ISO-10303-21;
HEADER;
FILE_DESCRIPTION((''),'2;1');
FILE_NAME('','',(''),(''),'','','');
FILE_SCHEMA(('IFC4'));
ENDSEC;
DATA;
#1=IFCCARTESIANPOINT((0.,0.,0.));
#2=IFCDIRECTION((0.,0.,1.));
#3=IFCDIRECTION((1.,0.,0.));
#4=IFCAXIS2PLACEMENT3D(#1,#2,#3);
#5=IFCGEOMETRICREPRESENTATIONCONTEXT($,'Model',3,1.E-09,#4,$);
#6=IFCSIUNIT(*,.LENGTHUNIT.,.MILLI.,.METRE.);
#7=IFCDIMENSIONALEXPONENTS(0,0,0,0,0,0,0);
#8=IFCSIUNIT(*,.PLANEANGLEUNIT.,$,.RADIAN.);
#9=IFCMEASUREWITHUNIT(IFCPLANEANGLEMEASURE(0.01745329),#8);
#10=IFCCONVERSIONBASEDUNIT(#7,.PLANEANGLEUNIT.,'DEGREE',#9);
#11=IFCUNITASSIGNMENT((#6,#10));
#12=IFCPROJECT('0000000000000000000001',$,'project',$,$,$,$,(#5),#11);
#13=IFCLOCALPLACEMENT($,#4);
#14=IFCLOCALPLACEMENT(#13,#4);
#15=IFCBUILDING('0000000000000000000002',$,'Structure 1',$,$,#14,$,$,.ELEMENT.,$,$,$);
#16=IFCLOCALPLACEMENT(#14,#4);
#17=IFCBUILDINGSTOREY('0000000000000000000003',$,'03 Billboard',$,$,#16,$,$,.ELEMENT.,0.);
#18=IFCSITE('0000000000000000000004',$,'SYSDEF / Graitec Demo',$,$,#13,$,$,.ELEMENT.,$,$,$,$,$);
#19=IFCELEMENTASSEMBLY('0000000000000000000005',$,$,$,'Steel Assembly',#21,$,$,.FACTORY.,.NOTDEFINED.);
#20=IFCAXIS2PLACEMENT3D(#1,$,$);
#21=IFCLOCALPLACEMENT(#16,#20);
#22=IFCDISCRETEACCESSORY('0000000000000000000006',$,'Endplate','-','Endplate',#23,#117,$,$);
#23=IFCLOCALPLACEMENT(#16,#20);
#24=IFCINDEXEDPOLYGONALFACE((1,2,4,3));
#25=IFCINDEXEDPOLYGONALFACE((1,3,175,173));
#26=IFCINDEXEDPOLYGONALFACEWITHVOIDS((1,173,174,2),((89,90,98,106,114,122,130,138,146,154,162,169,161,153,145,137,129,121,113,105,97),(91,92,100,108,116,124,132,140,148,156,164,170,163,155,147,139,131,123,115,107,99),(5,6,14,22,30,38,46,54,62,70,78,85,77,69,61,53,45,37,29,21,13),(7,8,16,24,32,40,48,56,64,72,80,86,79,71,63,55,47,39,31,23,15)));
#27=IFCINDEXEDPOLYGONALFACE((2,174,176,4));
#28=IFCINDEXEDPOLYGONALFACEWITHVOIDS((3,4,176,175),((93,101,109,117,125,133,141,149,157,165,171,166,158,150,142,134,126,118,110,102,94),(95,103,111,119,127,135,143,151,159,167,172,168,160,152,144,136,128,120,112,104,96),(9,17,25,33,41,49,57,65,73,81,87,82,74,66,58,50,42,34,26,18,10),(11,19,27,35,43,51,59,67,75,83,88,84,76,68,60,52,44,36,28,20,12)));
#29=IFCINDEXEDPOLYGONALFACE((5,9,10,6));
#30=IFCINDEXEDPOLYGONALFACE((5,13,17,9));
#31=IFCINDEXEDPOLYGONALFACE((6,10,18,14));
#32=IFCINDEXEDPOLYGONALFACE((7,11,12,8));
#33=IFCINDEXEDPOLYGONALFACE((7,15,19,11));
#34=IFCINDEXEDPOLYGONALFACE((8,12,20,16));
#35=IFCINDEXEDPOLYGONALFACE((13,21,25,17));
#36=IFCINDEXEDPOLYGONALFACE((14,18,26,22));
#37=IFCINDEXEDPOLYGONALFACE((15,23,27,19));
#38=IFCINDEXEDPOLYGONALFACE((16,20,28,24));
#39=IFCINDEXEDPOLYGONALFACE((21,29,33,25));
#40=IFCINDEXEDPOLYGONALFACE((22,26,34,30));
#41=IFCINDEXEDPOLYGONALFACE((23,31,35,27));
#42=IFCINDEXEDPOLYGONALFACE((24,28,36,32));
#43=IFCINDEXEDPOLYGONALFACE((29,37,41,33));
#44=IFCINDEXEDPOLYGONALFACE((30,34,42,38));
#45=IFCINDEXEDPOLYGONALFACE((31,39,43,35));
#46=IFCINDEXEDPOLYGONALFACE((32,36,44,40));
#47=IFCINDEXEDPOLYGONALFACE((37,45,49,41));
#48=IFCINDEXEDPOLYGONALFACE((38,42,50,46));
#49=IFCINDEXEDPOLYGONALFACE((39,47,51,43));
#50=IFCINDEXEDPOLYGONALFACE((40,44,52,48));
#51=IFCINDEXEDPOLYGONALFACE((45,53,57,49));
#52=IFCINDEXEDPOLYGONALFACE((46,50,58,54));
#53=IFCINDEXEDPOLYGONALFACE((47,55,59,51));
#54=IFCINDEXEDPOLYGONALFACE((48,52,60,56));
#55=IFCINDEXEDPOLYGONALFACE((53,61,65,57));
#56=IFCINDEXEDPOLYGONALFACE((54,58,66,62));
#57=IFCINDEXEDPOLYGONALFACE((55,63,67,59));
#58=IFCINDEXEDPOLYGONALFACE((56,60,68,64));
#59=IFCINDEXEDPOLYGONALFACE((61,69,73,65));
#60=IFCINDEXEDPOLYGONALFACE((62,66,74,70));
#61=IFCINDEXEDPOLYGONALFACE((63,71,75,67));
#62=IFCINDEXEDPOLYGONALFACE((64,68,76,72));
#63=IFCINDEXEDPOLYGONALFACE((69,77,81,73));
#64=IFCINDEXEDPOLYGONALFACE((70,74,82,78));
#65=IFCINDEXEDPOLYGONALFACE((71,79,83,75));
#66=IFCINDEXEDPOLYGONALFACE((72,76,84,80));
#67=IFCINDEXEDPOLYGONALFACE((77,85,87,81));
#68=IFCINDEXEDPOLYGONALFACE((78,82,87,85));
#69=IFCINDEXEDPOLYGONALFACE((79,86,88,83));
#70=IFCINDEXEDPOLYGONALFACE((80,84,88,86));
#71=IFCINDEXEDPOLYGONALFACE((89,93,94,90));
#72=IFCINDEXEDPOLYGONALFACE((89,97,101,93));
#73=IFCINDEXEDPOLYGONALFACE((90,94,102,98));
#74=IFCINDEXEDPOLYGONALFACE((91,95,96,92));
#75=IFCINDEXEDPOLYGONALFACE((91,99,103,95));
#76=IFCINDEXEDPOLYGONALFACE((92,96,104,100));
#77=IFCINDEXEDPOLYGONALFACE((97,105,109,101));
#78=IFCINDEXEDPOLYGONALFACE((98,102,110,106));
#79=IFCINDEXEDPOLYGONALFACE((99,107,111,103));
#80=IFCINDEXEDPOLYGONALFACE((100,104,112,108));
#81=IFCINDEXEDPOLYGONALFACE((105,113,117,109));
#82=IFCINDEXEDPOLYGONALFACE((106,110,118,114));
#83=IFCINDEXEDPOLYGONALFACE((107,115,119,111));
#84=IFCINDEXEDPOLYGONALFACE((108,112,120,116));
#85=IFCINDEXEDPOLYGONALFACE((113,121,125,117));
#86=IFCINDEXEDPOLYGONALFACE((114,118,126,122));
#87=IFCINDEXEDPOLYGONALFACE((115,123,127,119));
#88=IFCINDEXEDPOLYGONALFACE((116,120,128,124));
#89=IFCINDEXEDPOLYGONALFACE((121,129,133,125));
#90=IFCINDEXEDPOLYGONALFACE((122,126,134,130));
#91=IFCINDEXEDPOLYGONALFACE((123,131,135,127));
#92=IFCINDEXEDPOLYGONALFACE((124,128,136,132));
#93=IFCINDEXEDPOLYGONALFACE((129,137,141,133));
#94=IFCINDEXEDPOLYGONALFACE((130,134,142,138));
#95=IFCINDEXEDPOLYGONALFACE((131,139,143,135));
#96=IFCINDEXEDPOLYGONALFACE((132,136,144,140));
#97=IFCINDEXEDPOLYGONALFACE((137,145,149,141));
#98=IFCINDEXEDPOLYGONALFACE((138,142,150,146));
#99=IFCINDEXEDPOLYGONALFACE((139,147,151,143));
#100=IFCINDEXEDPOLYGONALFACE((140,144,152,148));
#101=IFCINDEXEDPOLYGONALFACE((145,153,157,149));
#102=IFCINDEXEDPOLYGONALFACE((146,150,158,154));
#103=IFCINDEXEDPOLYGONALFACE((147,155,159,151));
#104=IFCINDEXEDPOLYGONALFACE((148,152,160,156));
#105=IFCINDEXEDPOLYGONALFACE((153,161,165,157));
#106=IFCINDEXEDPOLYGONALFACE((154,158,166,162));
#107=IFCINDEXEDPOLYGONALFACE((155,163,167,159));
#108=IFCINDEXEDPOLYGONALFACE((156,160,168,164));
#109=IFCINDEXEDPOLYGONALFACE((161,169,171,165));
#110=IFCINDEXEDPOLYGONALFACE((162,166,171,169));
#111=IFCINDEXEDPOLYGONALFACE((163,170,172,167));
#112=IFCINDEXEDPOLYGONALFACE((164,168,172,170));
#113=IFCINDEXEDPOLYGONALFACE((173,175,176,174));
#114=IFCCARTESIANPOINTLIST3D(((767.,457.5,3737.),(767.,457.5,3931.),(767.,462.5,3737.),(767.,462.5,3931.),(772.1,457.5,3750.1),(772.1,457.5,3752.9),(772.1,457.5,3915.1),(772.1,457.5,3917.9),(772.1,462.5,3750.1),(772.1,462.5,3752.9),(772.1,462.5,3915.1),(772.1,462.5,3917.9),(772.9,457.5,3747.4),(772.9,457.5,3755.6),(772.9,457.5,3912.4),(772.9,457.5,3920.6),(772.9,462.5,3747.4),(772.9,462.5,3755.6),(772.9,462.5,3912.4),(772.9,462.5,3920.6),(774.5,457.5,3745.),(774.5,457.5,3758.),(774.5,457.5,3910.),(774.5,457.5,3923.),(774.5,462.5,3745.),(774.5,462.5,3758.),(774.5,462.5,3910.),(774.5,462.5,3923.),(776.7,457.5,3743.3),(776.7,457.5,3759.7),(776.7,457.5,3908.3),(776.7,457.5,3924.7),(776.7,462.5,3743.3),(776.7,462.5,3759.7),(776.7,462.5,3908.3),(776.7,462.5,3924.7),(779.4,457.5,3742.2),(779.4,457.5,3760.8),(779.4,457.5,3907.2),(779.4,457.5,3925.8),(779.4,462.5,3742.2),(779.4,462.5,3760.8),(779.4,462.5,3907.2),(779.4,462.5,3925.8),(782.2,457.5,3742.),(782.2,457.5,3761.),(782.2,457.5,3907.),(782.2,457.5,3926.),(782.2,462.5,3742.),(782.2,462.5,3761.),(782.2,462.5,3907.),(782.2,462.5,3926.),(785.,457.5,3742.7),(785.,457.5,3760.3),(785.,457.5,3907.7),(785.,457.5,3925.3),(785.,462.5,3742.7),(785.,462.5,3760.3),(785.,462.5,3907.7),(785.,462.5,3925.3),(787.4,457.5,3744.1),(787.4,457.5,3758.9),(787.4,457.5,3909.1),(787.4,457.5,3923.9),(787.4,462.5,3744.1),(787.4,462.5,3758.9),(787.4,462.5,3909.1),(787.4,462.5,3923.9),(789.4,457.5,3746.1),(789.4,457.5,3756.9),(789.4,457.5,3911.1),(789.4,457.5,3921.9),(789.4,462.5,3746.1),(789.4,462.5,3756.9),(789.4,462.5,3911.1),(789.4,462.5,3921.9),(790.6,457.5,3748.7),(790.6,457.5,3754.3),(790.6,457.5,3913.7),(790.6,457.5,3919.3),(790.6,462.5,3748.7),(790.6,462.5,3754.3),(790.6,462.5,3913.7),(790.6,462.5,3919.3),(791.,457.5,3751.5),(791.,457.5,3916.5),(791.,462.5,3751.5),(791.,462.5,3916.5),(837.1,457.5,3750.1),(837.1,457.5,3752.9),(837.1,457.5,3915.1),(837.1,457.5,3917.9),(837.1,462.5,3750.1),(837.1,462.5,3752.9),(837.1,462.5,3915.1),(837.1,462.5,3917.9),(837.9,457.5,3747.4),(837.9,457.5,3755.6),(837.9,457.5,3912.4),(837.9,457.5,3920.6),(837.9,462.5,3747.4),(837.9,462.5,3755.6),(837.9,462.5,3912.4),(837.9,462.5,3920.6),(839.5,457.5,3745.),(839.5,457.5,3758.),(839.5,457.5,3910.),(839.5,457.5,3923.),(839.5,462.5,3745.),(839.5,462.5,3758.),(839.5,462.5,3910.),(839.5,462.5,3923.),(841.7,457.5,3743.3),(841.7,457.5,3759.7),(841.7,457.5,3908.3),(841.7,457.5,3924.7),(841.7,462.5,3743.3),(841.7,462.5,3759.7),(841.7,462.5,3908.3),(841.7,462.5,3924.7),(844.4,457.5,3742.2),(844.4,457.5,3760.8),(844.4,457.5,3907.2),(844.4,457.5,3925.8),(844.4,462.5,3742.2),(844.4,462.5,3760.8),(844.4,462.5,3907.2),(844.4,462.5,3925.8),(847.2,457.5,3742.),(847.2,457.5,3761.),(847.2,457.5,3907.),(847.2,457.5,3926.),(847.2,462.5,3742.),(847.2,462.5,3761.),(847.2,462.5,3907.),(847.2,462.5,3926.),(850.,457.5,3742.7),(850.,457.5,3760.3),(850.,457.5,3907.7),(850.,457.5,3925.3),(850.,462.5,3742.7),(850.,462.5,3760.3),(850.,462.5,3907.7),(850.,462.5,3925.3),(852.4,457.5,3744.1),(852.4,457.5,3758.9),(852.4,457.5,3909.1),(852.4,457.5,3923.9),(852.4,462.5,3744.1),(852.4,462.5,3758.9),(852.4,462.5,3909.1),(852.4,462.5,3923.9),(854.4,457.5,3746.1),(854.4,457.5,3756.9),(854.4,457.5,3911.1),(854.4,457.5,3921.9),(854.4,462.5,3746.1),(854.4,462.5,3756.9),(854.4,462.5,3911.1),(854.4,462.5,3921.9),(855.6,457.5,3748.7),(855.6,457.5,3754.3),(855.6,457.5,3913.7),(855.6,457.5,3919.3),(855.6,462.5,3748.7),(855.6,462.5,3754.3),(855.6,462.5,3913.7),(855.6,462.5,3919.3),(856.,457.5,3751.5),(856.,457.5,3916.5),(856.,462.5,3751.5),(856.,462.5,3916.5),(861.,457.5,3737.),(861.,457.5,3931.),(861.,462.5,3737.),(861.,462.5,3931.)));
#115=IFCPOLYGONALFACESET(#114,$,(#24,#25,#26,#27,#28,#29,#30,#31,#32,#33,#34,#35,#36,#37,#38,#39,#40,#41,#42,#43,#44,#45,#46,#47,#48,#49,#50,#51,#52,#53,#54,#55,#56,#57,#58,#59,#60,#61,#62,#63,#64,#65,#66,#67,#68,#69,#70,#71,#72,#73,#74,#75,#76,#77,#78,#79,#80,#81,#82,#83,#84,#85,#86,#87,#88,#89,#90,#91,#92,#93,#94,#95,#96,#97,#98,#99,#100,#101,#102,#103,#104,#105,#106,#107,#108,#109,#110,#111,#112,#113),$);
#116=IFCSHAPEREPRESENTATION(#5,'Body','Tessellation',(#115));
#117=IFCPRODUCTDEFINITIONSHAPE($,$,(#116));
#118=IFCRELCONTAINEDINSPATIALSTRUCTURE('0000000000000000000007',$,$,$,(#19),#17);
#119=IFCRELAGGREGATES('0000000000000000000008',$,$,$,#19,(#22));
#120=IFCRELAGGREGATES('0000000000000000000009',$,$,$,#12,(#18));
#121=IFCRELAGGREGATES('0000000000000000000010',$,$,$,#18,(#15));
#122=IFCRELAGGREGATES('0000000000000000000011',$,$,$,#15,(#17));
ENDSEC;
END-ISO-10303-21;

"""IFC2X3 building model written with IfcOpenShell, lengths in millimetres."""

from ifc_helpers import new_model, entity, si_unit, converted_unit, frame, frame_2d, origin, origin_with_axes, place, context, project, spatial, polyline, circle, outline, extrude, element, aggregate, save


model = new_model("IFC2X3")

# Units and contexts
model_context = context("Model", 3, precision=1e-09, world=origin_with_axes())
ifc_project = project(units=[si_unit("LENGTHUNIT", "METRE", prefix="MILLI"), converted_unit("PLANEANGLEUNIT", "DEGREE", entity("IfcPlaneAngleMeasure", 0.01745329), si_unit("PLANEANGLEUNIT", "RADIAN"), dimensions=[0, 0, 0, 0, 0, 0, 0])], contexts=[model_context])

# Site, building, storey
site_placement = place(None, origin_with_axes())
site = spatial("IfcSite", under=ifc_project, at=site_placement, Name="SYSDEF / Graitec Demo", CompositionType="ELEMENT")
building_placement = place(site_placement, origin_with_axes())
building = spatial("IfcBuilding", under=site, at=building_placement, Name="Structure 1", CompositionType="ELEMENT")
storey_placement = place(building_placement, origin_with_axes())
storey = spatial("IfcBuildingStorey", under=building, at=storey_placement, Name="03 Billboard", CompositionType="ELEMENT", Elevation=0.0)

# Element assembly, discrete accessory, openings
assembly_1_placement = place(None, frame((-4406.3, 0.0, 3558.0), z_axis=(-1.0, 0.0, 0.0), x_axis=(0.0, -1.0, 0.0)))
assembly_1 = element("IfcElementAssembly", 1, at=assembly_1_placement, inside=storey, ObjectType="Steel Assembly", AssemblyPlace="FACTORY", PredefinedType="NOTDEFINED")
discrete_accessory_1_placement = place(assembly_1_placement, frame((-457.5, 373.0, -5173.3), z_axis=(-1.0, 0.0, 0.0), x_axis=(0.0, 0.0, -1.0)))
discrete_accessory_1 = element("IfcDiscreteAccessory", 2, at=discrete_accessory_1_placement, Name="Endplate", Description="-", ObjectType="Endplate", context=model_context, shape_type="SweptSolid", body=[
    extrude(outline(polyline([(0.0, 0.0), (94.0, 0.0), (94.0, 194.0), (0.0, 194.0), (0.0, 0.0)])), origin_with_axes(), (0.0, 0.0, 1.0), 5.0),
])
opening_1_placement = place(discrete_accessory_1_placement, frame((47.0, 97.0, 5.5), z_axis=(0.0, 0.0, -1.0), x_axis=(1.0, 0.0, 0.0)))
element("IfcOpeningElement", 3, at=opening_1_placement, cuts=discrete_accessory_1, ObjectType="Opening", context=model_context, shape_type="SweptSolid", body=[
    extrude(circle(Radius=9.5, at=frame_2d((32.5, 82.5), x_axis=(1.0, 0.0))), origin(), (0.0, 0.0, 1.0), 6.0),
])
opening_2_placement = place(discrete_accessory_1_placement, frame((47.0, 97.0, 5.5), z_axis=(0.0, 0.0, -1.0), x_axis=(1.0, 0.0, 0.0)))
element("IfcOpeningElement", 4, at=opening_2_placement, cuts=discrete_accessory_1, ObjectType="Opening", context=model_context, shape_type="SweptSolid", body=[
    extrude(circle(Radius=9.5, at=frame_2d((-32.5, 82.5), x_axis=(1.0, 0.0))), origin(), (0.0, 0.0, 1.0), 6.0),
])
opening_3_placement = place(discrete_accessory_1_placement, frame((47.0, 97.0, 5.5), z_axis=(0.0, 0.0, -1.0), x_axis=(1.0, 0.0, 0.0)))
element("IfcOpeningElement", 5, at=opening_3_placement, cuts=discrete_accessory_1, ObjectType="Opening", context=model_context, shape_type="SweptSolid", body=[
    extrude(circle(Radius=9.5, at=frame_2d((32.5, -82.5), x_axis=(1.0, 0.0))), origin(), (0.0, 0.0, 1.0), 6.0),
])
opening_4_placement = place(discrete_accessory_1_placement, frame((47.0, 97.0, 5.5), z_axis=(0.0, 0.0, -1.0), x_axis=(1.0, 0.0, 0.0)))
element("IfcOpeningElement", 6, at=opening_4_placement, cuts=discrete_accessory_1, ObjectType="Opening", context=model_context, shape_type="SweptSolid", body=[
    extrude(circle(Radius=9.5, at=frame_2d((-32.5, -82.5), x_axis=(1.0, 0.0))), origin(), (0.0, 0.0, 1.0), 6.0),
])
aggregate(assembly_1, [discrete_accessory_1])

save(model, "model.ifc")
